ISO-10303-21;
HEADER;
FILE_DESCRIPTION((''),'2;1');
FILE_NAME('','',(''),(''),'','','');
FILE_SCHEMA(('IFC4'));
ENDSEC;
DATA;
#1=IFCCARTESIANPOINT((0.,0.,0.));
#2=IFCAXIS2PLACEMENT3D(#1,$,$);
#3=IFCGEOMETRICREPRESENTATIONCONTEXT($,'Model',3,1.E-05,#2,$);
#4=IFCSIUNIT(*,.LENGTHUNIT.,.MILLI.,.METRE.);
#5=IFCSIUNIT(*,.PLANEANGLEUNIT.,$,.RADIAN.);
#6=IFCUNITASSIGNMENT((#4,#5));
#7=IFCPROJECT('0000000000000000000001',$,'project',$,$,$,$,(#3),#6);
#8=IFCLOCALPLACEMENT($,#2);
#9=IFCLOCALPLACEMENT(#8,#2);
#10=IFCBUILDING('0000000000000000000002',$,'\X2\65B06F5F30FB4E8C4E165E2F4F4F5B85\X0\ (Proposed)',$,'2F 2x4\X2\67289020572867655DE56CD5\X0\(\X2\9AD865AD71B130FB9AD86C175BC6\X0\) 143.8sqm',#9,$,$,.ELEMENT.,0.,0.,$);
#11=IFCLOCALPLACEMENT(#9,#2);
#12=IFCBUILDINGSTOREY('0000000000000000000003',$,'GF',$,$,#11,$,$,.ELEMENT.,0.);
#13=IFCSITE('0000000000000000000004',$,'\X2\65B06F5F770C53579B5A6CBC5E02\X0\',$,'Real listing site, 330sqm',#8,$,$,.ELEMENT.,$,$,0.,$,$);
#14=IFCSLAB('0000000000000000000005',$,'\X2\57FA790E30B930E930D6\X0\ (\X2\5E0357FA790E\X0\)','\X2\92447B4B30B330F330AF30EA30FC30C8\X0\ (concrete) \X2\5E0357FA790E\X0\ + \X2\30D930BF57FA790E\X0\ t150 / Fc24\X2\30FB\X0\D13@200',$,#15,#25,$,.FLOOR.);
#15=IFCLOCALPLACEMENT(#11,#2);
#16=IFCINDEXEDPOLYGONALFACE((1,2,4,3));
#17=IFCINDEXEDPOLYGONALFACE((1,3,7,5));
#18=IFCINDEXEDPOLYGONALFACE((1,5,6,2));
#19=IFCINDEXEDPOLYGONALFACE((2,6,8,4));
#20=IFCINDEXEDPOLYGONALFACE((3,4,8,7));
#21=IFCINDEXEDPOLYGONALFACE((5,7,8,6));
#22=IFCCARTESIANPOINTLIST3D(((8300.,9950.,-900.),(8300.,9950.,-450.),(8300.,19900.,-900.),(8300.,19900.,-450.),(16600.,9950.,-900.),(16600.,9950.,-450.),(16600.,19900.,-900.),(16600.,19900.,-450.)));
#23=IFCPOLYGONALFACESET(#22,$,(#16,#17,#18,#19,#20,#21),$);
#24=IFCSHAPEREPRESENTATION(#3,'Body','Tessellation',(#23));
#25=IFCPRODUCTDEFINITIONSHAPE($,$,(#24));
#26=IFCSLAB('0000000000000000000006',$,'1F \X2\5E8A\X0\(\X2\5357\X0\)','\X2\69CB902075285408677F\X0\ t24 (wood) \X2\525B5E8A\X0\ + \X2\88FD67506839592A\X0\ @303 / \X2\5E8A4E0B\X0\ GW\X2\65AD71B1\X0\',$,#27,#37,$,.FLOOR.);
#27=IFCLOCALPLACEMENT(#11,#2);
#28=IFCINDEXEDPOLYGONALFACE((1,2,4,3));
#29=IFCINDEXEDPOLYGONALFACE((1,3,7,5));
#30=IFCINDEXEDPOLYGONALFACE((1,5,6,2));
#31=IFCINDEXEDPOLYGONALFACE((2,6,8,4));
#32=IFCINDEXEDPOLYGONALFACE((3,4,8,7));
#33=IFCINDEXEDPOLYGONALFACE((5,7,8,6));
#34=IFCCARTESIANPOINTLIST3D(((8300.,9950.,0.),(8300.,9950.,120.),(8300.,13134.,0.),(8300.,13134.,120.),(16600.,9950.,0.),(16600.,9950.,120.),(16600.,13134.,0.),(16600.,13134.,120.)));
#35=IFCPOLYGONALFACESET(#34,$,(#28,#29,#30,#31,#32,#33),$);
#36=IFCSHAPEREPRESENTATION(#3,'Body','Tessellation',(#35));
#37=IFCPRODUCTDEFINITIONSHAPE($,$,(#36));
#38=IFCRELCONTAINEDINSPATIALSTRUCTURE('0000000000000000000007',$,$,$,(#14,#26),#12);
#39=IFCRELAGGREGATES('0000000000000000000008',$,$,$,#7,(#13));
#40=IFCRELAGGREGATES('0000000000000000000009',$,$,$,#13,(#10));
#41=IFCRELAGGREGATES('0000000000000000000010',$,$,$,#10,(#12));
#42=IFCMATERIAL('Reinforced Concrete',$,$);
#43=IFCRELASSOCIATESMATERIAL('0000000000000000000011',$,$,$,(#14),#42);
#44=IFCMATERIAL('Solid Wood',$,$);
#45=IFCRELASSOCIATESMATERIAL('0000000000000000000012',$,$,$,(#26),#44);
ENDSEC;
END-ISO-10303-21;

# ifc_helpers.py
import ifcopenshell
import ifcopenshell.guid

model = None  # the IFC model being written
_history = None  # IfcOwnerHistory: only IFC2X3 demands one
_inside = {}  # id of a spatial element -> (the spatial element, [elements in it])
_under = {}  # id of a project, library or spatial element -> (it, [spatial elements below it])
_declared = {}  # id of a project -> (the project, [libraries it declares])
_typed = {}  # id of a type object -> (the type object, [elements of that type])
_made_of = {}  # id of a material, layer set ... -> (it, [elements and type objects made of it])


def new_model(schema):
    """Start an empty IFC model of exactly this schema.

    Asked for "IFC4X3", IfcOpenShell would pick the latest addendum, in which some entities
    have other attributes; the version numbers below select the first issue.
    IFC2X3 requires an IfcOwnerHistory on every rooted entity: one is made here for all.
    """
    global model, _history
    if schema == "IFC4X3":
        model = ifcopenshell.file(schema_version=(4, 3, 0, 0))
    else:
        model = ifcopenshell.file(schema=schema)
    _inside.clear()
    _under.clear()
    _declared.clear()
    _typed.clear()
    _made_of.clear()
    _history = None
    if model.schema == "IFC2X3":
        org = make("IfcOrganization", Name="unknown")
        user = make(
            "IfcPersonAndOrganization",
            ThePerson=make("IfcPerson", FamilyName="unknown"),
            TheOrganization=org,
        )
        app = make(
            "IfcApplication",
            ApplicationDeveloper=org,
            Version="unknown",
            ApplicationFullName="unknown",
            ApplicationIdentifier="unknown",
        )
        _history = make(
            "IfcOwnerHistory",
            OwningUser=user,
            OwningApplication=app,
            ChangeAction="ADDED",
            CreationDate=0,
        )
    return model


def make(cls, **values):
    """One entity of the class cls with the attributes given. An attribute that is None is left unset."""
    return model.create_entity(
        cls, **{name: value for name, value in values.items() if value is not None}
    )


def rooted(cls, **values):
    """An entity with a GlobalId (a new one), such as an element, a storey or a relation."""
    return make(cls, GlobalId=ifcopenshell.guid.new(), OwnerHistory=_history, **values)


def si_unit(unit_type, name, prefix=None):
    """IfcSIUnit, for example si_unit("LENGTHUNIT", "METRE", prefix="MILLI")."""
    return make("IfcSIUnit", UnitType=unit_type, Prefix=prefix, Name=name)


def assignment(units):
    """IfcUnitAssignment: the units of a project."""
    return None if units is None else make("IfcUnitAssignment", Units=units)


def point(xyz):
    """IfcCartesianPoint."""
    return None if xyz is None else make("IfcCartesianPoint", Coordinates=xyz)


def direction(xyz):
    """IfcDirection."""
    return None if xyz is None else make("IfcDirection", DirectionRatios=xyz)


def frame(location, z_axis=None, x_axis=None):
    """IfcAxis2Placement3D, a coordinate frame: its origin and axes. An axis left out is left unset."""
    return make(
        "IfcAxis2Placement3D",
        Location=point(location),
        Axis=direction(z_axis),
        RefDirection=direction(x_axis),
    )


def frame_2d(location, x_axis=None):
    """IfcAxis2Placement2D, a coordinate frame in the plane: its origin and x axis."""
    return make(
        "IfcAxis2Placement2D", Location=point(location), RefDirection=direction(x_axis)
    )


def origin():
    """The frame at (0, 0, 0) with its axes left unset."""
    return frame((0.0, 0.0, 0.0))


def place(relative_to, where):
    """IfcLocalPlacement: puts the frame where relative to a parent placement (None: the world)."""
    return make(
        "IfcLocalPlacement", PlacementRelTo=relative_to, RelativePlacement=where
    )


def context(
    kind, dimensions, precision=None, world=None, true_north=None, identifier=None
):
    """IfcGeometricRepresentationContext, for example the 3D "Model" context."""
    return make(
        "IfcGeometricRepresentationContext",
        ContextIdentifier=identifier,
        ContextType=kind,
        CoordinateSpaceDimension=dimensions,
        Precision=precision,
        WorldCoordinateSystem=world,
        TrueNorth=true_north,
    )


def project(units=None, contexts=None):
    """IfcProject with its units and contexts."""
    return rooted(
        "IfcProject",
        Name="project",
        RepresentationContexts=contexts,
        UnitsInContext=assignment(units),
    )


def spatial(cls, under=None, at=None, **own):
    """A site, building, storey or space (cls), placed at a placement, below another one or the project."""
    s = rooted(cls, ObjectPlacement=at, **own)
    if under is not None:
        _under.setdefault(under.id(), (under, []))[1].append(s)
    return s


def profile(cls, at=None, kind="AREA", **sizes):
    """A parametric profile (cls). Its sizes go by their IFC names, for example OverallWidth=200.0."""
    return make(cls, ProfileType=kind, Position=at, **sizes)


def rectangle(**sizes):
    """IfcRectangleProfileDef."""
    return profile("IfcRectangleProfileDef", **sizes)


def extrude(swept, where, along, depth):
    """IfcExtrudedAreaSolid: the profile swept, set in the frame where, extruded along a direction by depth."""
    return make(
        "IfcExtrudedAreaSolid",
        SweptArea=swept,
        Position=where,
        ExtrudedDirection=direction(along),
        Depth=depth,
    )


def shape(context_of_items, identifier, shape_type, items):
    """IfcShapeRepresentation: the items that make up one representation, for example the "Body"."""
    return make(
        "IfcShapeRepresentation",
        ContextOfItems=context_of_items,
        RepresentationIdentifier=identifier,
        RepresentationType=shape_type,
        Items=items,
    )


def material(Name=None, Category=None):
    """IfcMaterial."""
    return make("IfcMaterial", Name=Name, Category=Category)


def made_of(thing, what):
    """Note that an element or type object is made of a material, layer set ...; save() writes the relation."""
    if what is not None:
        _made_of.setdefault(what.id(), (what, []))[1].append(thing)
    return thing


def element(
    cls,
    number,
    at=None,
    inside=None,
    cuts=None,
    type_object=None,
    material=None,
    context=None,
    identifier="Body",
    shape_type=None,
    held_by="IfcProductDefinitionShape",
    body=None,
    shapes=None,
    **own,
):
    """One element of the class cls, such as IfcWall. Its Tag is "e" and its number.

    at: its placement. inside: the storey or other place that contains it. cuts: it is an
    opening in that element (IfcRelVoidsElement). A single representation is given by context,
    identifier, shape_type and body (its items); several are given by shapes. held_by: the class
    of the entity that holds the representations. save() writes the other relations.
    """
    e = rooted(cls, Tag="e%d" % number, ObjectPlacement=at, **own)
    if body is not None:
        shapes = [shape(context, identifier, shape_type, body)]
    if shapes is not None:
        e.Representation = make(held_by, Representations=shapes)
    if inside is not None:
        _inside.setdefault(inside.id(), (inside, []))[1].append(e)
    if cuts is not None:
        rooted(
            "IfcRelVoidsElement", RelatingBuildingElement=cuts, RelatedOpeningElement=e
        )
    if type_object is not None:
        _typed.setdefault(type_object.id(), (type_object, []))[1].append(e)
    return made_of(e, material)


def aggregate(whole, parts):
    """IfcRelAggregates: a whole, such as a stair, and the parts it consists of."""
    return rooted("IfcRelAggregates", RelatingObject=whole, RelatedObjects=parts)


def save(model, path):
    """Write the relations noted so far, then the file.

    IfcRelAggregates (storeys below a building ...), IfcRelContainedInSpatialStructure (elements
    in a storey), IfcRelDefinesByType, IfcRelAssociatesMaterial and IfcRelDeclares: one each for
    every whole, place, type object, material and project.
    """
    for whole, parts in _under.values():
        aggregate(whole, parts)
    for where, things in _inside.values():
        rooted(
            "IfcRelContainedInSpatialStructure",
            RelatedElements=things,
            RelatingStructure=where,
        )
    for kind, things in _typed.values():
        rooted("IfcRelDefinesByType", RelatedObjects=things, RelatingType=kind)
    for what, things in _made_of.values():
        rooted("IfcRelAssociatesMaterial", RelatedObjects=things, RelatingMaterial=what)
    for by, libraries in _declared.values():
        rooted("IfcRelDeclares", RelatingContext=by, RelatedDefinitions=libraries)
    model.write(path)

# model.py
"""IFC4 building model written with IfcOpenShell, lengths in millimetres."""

from ifc_helpers import new_model, si_unit, frame, frame_2d, origin, place, context, project, spatial, rectangle, extrude, material, element, save


model = new_model("IFC4")

# Units and contexts
model_context = context("Model", 3, precision=1e-05, world=origin())
ifc_project = project(units=[si_unit("LENGTHUNIT", "METRE", prefix="MILLI"), si_unit("PLANEANGLEUNIT", "RADIAN")], contexts=[model_context])

# Site, building, storey
site_placement = place(None, origin())
site = spatial("IfcSite", under=ifc_project, at=site_placement, Name="新潟県南魚沼市", ObjectType="Real listing site, 330sqm", CompositionType="ELEMENT", RefElevation=0.0)
building_placement = place(site_placement, origin())
building = spatial("IfcBuilding", under=site, at=building_placement, Name="新潟・二世帯住宅 (Proposed)", ObjectType="2F 2x4木造在来工法(高断熱・高気密) 143.8sqm", CompositionType="ELEMENT", ElevationOfRefHeight=0.0, ElevationOfTerrain=0.0)
storey_placement = place(building_placement, origin())
storey = spatial("IfcBuildingStorey", under=building, at=storey_placement, Name="GF", CompositionType="ELEMENT", Elevation=0.0)

# Shared definitions
ifc_material_1 = material(Name="Solid Wood")

# Slabs
ifc_material_2 = material(Name="Reinforced Concrete")
slab_1_placement = place(storey_placement, frame((4150.0, 4975.0, -450.0)))
element("IfcSlab", 1, at=slab_1_placement, inside=storey, material=ifc_material_2, Name="基礎スラブ (布基礎)", Description="鉄筋コンクリート (concrete) 布基礎 + ベタ基礎 t150 / Fc24・D13@200", PredefinedType="FLOOR", context=model_context, shape_type="SweptSolid", body=[
    extrude(rectangle(XDim=8300.0, YDim=9950.0, at=frame_2d((4150.0, 4975.0))), frame((4150.0, 4975.0, -450.0)), (0.0, 0.0, 1.0), 450.0),
])
slab_2_placement = place(storey_placement, frame((4150.0, 4975.0, 0.0)))
element("IfcSlab", 2, at=slab_2_placement, inside=storey, material=ifc_material_1, Name="1F 床(南)", Description="構造用合板 t24 (wood) 剛床 + 製材根太 @303 / 床下 GW断熱", PredefinedType="FLOOR", context=model_context, shape_type="SweptSolid", body=[
    extrude(rectangle(XDim=8300.0, YDim=3184.0, at=frame_2d((4150.0, 1592.0))), frame((4150.0, 4975.0, 0.0)), (0.0, 0.0, 1.0), 120.0),
])

save(model, "model.ifc")
